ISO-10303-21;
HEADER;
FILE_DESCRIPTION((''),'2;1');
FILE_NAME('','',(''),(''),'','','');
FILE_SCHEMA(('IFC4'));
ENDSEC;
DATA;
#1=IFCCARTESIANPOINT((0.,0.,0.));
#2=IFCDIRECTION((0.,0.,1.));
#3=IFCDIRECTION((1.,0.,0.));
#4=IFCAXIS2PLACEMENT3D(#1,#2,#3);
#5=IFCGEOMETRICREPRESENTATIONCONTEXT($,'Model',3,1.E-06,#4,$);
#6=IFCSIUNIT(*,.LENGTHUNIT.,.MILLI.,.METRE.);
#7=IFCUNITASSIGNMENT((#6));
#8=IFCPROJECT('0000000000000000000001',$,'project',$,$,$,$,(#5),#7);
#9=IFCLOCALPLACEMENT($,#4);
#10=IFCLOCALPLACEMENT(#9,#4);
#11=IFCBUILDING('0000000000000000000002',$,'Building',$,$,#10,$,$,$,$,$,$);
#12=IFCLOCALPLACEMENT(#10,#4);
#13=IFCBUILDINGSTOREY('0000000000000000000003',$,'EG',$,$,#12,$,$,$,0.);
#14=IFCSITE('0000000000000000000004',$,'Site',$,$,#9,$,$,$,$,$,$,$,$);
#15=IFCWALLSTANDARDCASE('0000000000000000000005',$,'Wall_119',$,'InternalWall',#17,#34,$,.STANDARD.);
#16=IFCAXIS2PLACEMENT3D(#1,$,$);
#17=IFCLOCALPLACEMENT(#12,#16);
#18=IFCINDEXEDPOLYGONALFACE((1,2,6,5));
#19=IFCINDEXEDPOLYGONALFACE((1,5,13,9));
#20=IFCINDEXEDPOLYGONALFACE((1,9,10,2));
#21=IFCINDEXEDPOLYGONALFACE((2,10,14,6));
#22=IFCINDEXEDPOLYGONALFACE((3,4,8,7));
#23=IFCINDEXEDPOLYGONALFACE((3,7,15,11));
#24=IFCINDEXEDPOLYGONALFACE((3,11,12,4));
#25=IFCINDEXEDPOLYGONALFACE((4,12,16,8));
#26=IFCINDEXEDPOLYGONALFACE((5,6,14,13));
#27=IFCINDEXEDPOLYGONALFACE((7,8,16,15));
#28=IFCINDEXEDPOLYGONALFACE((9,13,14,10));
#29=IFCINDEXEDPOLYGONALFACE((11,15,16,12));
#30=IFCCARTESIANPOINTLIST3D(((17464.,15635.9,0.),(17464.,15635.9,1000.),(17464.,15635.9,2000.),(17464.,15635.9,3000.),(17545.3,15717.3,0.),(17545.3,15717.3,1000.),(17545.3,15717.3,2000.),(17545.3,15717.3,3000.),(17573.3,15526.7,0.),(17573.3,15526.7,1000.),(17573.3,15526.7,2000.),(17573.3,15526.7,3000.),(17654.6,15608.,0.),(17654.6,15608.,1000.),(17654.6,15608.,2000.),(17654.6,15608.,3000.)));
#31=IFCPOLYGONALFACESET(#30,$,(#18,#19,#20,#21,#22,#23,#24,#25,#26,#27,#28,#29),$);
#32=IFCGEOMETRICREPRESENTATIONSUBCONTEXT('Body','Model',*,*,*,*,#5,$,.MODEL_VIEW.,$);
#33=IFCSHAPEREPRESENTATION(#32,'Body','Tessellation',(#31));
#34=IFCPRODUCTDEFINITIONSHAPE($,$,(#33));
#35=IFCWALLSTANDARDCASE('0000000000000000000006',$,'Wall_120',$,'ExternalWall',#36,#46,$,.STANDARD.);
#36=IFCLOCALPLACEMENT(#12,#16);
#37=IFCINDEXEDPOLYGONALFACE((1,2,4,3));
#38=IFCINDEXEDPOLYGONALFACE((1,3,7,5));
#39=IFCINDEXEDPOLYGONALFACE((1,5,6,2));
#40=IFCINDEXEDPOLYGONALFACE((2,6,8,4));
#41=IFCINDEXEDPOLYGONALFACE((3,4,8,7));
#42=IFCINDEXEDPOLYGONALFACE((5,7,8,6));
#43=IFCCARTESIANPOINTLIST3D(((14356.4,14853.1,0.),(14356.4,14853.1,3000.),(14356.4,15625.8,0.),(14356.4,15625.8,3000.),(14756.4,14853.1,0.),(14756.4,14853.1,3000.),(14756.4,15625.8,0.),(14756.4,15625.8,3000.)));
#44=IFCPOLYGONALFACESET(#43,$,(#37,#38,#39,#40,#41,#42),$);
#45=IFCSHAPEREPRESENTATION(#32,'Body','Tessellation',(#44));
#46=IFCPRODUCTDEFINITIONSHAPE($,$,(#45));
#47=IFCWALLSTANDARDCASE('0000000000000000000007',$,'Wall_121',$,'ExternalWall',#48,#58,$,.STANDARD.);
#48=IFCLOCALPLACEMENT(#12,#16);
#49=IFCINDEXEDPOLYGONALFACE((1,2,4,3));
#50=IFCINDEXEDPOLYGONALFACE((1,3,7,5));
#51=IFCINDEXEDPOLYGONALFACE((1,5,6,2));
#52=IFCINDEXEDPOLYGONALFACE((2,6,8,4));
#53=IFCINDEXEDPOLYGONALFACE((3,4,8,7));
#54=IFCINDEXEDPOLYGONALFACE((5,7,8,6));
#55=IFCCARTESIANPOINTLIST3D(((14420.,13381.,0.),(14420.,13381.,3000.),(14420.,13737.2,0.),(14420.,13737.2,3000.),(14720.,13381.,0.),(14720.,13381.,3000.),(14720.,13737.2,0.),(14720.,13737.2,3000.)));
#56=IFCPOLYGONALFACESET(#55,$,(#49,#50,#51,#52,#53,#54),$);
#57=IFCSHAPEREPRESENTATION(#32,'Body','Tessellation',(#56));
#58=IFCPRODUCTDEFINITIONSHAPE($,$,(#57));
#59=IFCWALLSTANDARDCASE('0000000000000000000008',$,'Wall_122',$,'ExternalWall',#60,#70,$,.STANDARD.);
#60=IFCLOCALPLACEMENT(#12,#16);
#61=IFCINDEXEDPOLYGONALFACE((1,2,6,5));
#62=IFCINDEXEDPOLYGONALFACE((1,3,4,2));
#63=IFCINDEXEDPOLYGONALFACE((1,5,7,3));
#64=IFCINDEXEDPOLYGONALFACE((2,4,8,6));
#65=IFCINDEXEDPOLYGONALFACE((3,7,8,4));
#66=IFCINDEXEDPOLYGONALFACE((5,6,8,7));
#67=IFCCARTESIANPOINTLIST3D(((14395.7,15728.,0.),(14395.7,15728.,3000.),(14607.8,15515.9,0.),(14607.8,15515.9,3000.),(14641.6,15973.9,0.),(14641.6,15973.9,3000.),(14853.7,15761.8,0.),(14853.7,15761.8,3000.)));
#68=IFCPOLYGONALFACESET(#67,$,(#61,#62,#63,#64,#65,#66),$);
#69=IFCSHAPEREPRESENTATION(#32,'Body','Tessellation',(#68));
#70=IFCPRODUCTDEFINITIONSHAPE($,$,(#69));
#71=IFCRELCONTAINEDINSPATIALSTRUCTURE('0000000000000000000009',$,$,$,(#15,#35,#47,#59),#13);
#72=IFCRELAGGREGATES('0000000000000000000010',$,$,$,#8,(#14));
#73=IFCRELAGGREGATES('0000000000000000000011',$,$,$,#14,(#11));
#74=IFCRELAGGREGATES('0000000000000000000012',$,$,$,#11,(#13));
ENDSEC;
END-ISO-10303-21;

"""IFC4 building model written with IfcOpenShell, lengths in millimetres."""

from ifc_helpers import new_model, si_unit, frame, origin_with_axes, place, context, subcontext, project, spatial, rectangle, extrude, element, save


model = new_model("IFC4")

# Units and contexts
model_context = context("Model", 3, precision=1e-06, world=origin_with_axes())
body_context = subcontext(model_context, "Body", "Model", "MODEL_VIEW")
ifc_project = project(units=[si_unit("LENGTHUNIT", "METRE", prefix="MILLI")], contexts=[model_context])

# Site, building, storey
site_placement = place(None, origin_with_axes())
site = spatial("IfcSite", under=ifc_project, at=site_placement, Name="Site")
building_placement = place(site_placement, origin_with_axes())
building = spatial("IfcBuilding", under=site, at=building_placement, Name="Building")
storey_placement = place(building_placement, origin_with_axes())
storey = spatial("IfcBuildingStorey", under=building, at=storey_placement, Name="EG", Elevation=0.0)

# Wall, opening
wall_1_placement = place(storey_placement, origin_with_axes())
wall_1 = element("IfcWallStandardCase", 1, at=wall_1_placement, inside=storey, Name="Wall_119", ObjectType="InternalWall", PredefinedType="STANDARD", context=body_context, shape_type="SweptSolid", body=[
    extrude(rectangle(XDim=154.6, YDim=115.0), frame((17559.3, 15622.0, 0.0), z_axis=(0.0, 0.0, 1.0), x_axis=(-0.707107, 0.707107, 0.0)), (0.0, 0.0, 1.0), 3000.0),
])
opening_1_placement = place(wall_1_placement, origin_with_axes())
element("IfcOpeningElement", 2, at=opening_1_placement, inside=storey, cuts=wall_1, context=body_context, shape_type="SweptSolid", body=[
    extrude(rectangle(XDim=1620.5, YDim=115.0), frame((18049.0, 15132.3, 1000.0), z_axis=(0.0, 0.0, 1.0), x_axis=(-0.707107, 0.707107, 0.0)), (0.0, 0.0, 1.0), 1000.0),
])

# Walls
wall_2_placement = place(storey_placement, origin_with_axes())
element("IfcWallStandardCase", 3, at=wall_2_placement, inside=storey, Name="Wall_120", ObjectType="ExternalWall", PredefinedType="STANDARD", context=body_context, shape_type="SweptSolid", body=[
    extrude(rectangle(XDim=772.8, YDim=400.0), frame((14556.4, 15239.4, 0.0), z_axis=(0.0, 0.0, 1.0), x_axis=(0.0, 1.0, 0.0)), (0.0, 0.0, 1.0), 3000.0),
])
wall_3_placement = place(storey_placement, origin_with_axes())
element("IfcWallStandardCase", 4, at=wall_3_placement, inside=storey, Name="Wall_121", ObjectType="ExternalWall", PredefinedType="STANDARD", context=body_context, shape_type="SweptSolid", body=[
    extrude(rectangle(XDim=356.2, YDim=300.0), frame((14570.0, 13559.1, 0.0), z_axis=(0.0, 0.0, 1.0), x_axis=(0.0, -1.0, 0.0)), (0.0, 0.0, 1.0), 3000.0),
])
wall_4_placement = place(storey_placement, origin_with_axes())
element("IfcWallStandardCase", 5, at=wall_4_placement, inside=storey, Name="Wall_122", ObjectType="ExternalWall", PredefinedType="STANDARD", context=body_context, shape_type="SweptSolid", body=[
    extrude(rectangle(XDim=347.8, YDim=300.0), frame((14624.7, 15744.9, 0.0), z_axis=(0.0, 0.0, 1.0), x_axis=(0.707107, 0.707107, 0.0)), (0.0, 0.0, 1.0), 3000.0),
])

save(model, "model.ifc")
